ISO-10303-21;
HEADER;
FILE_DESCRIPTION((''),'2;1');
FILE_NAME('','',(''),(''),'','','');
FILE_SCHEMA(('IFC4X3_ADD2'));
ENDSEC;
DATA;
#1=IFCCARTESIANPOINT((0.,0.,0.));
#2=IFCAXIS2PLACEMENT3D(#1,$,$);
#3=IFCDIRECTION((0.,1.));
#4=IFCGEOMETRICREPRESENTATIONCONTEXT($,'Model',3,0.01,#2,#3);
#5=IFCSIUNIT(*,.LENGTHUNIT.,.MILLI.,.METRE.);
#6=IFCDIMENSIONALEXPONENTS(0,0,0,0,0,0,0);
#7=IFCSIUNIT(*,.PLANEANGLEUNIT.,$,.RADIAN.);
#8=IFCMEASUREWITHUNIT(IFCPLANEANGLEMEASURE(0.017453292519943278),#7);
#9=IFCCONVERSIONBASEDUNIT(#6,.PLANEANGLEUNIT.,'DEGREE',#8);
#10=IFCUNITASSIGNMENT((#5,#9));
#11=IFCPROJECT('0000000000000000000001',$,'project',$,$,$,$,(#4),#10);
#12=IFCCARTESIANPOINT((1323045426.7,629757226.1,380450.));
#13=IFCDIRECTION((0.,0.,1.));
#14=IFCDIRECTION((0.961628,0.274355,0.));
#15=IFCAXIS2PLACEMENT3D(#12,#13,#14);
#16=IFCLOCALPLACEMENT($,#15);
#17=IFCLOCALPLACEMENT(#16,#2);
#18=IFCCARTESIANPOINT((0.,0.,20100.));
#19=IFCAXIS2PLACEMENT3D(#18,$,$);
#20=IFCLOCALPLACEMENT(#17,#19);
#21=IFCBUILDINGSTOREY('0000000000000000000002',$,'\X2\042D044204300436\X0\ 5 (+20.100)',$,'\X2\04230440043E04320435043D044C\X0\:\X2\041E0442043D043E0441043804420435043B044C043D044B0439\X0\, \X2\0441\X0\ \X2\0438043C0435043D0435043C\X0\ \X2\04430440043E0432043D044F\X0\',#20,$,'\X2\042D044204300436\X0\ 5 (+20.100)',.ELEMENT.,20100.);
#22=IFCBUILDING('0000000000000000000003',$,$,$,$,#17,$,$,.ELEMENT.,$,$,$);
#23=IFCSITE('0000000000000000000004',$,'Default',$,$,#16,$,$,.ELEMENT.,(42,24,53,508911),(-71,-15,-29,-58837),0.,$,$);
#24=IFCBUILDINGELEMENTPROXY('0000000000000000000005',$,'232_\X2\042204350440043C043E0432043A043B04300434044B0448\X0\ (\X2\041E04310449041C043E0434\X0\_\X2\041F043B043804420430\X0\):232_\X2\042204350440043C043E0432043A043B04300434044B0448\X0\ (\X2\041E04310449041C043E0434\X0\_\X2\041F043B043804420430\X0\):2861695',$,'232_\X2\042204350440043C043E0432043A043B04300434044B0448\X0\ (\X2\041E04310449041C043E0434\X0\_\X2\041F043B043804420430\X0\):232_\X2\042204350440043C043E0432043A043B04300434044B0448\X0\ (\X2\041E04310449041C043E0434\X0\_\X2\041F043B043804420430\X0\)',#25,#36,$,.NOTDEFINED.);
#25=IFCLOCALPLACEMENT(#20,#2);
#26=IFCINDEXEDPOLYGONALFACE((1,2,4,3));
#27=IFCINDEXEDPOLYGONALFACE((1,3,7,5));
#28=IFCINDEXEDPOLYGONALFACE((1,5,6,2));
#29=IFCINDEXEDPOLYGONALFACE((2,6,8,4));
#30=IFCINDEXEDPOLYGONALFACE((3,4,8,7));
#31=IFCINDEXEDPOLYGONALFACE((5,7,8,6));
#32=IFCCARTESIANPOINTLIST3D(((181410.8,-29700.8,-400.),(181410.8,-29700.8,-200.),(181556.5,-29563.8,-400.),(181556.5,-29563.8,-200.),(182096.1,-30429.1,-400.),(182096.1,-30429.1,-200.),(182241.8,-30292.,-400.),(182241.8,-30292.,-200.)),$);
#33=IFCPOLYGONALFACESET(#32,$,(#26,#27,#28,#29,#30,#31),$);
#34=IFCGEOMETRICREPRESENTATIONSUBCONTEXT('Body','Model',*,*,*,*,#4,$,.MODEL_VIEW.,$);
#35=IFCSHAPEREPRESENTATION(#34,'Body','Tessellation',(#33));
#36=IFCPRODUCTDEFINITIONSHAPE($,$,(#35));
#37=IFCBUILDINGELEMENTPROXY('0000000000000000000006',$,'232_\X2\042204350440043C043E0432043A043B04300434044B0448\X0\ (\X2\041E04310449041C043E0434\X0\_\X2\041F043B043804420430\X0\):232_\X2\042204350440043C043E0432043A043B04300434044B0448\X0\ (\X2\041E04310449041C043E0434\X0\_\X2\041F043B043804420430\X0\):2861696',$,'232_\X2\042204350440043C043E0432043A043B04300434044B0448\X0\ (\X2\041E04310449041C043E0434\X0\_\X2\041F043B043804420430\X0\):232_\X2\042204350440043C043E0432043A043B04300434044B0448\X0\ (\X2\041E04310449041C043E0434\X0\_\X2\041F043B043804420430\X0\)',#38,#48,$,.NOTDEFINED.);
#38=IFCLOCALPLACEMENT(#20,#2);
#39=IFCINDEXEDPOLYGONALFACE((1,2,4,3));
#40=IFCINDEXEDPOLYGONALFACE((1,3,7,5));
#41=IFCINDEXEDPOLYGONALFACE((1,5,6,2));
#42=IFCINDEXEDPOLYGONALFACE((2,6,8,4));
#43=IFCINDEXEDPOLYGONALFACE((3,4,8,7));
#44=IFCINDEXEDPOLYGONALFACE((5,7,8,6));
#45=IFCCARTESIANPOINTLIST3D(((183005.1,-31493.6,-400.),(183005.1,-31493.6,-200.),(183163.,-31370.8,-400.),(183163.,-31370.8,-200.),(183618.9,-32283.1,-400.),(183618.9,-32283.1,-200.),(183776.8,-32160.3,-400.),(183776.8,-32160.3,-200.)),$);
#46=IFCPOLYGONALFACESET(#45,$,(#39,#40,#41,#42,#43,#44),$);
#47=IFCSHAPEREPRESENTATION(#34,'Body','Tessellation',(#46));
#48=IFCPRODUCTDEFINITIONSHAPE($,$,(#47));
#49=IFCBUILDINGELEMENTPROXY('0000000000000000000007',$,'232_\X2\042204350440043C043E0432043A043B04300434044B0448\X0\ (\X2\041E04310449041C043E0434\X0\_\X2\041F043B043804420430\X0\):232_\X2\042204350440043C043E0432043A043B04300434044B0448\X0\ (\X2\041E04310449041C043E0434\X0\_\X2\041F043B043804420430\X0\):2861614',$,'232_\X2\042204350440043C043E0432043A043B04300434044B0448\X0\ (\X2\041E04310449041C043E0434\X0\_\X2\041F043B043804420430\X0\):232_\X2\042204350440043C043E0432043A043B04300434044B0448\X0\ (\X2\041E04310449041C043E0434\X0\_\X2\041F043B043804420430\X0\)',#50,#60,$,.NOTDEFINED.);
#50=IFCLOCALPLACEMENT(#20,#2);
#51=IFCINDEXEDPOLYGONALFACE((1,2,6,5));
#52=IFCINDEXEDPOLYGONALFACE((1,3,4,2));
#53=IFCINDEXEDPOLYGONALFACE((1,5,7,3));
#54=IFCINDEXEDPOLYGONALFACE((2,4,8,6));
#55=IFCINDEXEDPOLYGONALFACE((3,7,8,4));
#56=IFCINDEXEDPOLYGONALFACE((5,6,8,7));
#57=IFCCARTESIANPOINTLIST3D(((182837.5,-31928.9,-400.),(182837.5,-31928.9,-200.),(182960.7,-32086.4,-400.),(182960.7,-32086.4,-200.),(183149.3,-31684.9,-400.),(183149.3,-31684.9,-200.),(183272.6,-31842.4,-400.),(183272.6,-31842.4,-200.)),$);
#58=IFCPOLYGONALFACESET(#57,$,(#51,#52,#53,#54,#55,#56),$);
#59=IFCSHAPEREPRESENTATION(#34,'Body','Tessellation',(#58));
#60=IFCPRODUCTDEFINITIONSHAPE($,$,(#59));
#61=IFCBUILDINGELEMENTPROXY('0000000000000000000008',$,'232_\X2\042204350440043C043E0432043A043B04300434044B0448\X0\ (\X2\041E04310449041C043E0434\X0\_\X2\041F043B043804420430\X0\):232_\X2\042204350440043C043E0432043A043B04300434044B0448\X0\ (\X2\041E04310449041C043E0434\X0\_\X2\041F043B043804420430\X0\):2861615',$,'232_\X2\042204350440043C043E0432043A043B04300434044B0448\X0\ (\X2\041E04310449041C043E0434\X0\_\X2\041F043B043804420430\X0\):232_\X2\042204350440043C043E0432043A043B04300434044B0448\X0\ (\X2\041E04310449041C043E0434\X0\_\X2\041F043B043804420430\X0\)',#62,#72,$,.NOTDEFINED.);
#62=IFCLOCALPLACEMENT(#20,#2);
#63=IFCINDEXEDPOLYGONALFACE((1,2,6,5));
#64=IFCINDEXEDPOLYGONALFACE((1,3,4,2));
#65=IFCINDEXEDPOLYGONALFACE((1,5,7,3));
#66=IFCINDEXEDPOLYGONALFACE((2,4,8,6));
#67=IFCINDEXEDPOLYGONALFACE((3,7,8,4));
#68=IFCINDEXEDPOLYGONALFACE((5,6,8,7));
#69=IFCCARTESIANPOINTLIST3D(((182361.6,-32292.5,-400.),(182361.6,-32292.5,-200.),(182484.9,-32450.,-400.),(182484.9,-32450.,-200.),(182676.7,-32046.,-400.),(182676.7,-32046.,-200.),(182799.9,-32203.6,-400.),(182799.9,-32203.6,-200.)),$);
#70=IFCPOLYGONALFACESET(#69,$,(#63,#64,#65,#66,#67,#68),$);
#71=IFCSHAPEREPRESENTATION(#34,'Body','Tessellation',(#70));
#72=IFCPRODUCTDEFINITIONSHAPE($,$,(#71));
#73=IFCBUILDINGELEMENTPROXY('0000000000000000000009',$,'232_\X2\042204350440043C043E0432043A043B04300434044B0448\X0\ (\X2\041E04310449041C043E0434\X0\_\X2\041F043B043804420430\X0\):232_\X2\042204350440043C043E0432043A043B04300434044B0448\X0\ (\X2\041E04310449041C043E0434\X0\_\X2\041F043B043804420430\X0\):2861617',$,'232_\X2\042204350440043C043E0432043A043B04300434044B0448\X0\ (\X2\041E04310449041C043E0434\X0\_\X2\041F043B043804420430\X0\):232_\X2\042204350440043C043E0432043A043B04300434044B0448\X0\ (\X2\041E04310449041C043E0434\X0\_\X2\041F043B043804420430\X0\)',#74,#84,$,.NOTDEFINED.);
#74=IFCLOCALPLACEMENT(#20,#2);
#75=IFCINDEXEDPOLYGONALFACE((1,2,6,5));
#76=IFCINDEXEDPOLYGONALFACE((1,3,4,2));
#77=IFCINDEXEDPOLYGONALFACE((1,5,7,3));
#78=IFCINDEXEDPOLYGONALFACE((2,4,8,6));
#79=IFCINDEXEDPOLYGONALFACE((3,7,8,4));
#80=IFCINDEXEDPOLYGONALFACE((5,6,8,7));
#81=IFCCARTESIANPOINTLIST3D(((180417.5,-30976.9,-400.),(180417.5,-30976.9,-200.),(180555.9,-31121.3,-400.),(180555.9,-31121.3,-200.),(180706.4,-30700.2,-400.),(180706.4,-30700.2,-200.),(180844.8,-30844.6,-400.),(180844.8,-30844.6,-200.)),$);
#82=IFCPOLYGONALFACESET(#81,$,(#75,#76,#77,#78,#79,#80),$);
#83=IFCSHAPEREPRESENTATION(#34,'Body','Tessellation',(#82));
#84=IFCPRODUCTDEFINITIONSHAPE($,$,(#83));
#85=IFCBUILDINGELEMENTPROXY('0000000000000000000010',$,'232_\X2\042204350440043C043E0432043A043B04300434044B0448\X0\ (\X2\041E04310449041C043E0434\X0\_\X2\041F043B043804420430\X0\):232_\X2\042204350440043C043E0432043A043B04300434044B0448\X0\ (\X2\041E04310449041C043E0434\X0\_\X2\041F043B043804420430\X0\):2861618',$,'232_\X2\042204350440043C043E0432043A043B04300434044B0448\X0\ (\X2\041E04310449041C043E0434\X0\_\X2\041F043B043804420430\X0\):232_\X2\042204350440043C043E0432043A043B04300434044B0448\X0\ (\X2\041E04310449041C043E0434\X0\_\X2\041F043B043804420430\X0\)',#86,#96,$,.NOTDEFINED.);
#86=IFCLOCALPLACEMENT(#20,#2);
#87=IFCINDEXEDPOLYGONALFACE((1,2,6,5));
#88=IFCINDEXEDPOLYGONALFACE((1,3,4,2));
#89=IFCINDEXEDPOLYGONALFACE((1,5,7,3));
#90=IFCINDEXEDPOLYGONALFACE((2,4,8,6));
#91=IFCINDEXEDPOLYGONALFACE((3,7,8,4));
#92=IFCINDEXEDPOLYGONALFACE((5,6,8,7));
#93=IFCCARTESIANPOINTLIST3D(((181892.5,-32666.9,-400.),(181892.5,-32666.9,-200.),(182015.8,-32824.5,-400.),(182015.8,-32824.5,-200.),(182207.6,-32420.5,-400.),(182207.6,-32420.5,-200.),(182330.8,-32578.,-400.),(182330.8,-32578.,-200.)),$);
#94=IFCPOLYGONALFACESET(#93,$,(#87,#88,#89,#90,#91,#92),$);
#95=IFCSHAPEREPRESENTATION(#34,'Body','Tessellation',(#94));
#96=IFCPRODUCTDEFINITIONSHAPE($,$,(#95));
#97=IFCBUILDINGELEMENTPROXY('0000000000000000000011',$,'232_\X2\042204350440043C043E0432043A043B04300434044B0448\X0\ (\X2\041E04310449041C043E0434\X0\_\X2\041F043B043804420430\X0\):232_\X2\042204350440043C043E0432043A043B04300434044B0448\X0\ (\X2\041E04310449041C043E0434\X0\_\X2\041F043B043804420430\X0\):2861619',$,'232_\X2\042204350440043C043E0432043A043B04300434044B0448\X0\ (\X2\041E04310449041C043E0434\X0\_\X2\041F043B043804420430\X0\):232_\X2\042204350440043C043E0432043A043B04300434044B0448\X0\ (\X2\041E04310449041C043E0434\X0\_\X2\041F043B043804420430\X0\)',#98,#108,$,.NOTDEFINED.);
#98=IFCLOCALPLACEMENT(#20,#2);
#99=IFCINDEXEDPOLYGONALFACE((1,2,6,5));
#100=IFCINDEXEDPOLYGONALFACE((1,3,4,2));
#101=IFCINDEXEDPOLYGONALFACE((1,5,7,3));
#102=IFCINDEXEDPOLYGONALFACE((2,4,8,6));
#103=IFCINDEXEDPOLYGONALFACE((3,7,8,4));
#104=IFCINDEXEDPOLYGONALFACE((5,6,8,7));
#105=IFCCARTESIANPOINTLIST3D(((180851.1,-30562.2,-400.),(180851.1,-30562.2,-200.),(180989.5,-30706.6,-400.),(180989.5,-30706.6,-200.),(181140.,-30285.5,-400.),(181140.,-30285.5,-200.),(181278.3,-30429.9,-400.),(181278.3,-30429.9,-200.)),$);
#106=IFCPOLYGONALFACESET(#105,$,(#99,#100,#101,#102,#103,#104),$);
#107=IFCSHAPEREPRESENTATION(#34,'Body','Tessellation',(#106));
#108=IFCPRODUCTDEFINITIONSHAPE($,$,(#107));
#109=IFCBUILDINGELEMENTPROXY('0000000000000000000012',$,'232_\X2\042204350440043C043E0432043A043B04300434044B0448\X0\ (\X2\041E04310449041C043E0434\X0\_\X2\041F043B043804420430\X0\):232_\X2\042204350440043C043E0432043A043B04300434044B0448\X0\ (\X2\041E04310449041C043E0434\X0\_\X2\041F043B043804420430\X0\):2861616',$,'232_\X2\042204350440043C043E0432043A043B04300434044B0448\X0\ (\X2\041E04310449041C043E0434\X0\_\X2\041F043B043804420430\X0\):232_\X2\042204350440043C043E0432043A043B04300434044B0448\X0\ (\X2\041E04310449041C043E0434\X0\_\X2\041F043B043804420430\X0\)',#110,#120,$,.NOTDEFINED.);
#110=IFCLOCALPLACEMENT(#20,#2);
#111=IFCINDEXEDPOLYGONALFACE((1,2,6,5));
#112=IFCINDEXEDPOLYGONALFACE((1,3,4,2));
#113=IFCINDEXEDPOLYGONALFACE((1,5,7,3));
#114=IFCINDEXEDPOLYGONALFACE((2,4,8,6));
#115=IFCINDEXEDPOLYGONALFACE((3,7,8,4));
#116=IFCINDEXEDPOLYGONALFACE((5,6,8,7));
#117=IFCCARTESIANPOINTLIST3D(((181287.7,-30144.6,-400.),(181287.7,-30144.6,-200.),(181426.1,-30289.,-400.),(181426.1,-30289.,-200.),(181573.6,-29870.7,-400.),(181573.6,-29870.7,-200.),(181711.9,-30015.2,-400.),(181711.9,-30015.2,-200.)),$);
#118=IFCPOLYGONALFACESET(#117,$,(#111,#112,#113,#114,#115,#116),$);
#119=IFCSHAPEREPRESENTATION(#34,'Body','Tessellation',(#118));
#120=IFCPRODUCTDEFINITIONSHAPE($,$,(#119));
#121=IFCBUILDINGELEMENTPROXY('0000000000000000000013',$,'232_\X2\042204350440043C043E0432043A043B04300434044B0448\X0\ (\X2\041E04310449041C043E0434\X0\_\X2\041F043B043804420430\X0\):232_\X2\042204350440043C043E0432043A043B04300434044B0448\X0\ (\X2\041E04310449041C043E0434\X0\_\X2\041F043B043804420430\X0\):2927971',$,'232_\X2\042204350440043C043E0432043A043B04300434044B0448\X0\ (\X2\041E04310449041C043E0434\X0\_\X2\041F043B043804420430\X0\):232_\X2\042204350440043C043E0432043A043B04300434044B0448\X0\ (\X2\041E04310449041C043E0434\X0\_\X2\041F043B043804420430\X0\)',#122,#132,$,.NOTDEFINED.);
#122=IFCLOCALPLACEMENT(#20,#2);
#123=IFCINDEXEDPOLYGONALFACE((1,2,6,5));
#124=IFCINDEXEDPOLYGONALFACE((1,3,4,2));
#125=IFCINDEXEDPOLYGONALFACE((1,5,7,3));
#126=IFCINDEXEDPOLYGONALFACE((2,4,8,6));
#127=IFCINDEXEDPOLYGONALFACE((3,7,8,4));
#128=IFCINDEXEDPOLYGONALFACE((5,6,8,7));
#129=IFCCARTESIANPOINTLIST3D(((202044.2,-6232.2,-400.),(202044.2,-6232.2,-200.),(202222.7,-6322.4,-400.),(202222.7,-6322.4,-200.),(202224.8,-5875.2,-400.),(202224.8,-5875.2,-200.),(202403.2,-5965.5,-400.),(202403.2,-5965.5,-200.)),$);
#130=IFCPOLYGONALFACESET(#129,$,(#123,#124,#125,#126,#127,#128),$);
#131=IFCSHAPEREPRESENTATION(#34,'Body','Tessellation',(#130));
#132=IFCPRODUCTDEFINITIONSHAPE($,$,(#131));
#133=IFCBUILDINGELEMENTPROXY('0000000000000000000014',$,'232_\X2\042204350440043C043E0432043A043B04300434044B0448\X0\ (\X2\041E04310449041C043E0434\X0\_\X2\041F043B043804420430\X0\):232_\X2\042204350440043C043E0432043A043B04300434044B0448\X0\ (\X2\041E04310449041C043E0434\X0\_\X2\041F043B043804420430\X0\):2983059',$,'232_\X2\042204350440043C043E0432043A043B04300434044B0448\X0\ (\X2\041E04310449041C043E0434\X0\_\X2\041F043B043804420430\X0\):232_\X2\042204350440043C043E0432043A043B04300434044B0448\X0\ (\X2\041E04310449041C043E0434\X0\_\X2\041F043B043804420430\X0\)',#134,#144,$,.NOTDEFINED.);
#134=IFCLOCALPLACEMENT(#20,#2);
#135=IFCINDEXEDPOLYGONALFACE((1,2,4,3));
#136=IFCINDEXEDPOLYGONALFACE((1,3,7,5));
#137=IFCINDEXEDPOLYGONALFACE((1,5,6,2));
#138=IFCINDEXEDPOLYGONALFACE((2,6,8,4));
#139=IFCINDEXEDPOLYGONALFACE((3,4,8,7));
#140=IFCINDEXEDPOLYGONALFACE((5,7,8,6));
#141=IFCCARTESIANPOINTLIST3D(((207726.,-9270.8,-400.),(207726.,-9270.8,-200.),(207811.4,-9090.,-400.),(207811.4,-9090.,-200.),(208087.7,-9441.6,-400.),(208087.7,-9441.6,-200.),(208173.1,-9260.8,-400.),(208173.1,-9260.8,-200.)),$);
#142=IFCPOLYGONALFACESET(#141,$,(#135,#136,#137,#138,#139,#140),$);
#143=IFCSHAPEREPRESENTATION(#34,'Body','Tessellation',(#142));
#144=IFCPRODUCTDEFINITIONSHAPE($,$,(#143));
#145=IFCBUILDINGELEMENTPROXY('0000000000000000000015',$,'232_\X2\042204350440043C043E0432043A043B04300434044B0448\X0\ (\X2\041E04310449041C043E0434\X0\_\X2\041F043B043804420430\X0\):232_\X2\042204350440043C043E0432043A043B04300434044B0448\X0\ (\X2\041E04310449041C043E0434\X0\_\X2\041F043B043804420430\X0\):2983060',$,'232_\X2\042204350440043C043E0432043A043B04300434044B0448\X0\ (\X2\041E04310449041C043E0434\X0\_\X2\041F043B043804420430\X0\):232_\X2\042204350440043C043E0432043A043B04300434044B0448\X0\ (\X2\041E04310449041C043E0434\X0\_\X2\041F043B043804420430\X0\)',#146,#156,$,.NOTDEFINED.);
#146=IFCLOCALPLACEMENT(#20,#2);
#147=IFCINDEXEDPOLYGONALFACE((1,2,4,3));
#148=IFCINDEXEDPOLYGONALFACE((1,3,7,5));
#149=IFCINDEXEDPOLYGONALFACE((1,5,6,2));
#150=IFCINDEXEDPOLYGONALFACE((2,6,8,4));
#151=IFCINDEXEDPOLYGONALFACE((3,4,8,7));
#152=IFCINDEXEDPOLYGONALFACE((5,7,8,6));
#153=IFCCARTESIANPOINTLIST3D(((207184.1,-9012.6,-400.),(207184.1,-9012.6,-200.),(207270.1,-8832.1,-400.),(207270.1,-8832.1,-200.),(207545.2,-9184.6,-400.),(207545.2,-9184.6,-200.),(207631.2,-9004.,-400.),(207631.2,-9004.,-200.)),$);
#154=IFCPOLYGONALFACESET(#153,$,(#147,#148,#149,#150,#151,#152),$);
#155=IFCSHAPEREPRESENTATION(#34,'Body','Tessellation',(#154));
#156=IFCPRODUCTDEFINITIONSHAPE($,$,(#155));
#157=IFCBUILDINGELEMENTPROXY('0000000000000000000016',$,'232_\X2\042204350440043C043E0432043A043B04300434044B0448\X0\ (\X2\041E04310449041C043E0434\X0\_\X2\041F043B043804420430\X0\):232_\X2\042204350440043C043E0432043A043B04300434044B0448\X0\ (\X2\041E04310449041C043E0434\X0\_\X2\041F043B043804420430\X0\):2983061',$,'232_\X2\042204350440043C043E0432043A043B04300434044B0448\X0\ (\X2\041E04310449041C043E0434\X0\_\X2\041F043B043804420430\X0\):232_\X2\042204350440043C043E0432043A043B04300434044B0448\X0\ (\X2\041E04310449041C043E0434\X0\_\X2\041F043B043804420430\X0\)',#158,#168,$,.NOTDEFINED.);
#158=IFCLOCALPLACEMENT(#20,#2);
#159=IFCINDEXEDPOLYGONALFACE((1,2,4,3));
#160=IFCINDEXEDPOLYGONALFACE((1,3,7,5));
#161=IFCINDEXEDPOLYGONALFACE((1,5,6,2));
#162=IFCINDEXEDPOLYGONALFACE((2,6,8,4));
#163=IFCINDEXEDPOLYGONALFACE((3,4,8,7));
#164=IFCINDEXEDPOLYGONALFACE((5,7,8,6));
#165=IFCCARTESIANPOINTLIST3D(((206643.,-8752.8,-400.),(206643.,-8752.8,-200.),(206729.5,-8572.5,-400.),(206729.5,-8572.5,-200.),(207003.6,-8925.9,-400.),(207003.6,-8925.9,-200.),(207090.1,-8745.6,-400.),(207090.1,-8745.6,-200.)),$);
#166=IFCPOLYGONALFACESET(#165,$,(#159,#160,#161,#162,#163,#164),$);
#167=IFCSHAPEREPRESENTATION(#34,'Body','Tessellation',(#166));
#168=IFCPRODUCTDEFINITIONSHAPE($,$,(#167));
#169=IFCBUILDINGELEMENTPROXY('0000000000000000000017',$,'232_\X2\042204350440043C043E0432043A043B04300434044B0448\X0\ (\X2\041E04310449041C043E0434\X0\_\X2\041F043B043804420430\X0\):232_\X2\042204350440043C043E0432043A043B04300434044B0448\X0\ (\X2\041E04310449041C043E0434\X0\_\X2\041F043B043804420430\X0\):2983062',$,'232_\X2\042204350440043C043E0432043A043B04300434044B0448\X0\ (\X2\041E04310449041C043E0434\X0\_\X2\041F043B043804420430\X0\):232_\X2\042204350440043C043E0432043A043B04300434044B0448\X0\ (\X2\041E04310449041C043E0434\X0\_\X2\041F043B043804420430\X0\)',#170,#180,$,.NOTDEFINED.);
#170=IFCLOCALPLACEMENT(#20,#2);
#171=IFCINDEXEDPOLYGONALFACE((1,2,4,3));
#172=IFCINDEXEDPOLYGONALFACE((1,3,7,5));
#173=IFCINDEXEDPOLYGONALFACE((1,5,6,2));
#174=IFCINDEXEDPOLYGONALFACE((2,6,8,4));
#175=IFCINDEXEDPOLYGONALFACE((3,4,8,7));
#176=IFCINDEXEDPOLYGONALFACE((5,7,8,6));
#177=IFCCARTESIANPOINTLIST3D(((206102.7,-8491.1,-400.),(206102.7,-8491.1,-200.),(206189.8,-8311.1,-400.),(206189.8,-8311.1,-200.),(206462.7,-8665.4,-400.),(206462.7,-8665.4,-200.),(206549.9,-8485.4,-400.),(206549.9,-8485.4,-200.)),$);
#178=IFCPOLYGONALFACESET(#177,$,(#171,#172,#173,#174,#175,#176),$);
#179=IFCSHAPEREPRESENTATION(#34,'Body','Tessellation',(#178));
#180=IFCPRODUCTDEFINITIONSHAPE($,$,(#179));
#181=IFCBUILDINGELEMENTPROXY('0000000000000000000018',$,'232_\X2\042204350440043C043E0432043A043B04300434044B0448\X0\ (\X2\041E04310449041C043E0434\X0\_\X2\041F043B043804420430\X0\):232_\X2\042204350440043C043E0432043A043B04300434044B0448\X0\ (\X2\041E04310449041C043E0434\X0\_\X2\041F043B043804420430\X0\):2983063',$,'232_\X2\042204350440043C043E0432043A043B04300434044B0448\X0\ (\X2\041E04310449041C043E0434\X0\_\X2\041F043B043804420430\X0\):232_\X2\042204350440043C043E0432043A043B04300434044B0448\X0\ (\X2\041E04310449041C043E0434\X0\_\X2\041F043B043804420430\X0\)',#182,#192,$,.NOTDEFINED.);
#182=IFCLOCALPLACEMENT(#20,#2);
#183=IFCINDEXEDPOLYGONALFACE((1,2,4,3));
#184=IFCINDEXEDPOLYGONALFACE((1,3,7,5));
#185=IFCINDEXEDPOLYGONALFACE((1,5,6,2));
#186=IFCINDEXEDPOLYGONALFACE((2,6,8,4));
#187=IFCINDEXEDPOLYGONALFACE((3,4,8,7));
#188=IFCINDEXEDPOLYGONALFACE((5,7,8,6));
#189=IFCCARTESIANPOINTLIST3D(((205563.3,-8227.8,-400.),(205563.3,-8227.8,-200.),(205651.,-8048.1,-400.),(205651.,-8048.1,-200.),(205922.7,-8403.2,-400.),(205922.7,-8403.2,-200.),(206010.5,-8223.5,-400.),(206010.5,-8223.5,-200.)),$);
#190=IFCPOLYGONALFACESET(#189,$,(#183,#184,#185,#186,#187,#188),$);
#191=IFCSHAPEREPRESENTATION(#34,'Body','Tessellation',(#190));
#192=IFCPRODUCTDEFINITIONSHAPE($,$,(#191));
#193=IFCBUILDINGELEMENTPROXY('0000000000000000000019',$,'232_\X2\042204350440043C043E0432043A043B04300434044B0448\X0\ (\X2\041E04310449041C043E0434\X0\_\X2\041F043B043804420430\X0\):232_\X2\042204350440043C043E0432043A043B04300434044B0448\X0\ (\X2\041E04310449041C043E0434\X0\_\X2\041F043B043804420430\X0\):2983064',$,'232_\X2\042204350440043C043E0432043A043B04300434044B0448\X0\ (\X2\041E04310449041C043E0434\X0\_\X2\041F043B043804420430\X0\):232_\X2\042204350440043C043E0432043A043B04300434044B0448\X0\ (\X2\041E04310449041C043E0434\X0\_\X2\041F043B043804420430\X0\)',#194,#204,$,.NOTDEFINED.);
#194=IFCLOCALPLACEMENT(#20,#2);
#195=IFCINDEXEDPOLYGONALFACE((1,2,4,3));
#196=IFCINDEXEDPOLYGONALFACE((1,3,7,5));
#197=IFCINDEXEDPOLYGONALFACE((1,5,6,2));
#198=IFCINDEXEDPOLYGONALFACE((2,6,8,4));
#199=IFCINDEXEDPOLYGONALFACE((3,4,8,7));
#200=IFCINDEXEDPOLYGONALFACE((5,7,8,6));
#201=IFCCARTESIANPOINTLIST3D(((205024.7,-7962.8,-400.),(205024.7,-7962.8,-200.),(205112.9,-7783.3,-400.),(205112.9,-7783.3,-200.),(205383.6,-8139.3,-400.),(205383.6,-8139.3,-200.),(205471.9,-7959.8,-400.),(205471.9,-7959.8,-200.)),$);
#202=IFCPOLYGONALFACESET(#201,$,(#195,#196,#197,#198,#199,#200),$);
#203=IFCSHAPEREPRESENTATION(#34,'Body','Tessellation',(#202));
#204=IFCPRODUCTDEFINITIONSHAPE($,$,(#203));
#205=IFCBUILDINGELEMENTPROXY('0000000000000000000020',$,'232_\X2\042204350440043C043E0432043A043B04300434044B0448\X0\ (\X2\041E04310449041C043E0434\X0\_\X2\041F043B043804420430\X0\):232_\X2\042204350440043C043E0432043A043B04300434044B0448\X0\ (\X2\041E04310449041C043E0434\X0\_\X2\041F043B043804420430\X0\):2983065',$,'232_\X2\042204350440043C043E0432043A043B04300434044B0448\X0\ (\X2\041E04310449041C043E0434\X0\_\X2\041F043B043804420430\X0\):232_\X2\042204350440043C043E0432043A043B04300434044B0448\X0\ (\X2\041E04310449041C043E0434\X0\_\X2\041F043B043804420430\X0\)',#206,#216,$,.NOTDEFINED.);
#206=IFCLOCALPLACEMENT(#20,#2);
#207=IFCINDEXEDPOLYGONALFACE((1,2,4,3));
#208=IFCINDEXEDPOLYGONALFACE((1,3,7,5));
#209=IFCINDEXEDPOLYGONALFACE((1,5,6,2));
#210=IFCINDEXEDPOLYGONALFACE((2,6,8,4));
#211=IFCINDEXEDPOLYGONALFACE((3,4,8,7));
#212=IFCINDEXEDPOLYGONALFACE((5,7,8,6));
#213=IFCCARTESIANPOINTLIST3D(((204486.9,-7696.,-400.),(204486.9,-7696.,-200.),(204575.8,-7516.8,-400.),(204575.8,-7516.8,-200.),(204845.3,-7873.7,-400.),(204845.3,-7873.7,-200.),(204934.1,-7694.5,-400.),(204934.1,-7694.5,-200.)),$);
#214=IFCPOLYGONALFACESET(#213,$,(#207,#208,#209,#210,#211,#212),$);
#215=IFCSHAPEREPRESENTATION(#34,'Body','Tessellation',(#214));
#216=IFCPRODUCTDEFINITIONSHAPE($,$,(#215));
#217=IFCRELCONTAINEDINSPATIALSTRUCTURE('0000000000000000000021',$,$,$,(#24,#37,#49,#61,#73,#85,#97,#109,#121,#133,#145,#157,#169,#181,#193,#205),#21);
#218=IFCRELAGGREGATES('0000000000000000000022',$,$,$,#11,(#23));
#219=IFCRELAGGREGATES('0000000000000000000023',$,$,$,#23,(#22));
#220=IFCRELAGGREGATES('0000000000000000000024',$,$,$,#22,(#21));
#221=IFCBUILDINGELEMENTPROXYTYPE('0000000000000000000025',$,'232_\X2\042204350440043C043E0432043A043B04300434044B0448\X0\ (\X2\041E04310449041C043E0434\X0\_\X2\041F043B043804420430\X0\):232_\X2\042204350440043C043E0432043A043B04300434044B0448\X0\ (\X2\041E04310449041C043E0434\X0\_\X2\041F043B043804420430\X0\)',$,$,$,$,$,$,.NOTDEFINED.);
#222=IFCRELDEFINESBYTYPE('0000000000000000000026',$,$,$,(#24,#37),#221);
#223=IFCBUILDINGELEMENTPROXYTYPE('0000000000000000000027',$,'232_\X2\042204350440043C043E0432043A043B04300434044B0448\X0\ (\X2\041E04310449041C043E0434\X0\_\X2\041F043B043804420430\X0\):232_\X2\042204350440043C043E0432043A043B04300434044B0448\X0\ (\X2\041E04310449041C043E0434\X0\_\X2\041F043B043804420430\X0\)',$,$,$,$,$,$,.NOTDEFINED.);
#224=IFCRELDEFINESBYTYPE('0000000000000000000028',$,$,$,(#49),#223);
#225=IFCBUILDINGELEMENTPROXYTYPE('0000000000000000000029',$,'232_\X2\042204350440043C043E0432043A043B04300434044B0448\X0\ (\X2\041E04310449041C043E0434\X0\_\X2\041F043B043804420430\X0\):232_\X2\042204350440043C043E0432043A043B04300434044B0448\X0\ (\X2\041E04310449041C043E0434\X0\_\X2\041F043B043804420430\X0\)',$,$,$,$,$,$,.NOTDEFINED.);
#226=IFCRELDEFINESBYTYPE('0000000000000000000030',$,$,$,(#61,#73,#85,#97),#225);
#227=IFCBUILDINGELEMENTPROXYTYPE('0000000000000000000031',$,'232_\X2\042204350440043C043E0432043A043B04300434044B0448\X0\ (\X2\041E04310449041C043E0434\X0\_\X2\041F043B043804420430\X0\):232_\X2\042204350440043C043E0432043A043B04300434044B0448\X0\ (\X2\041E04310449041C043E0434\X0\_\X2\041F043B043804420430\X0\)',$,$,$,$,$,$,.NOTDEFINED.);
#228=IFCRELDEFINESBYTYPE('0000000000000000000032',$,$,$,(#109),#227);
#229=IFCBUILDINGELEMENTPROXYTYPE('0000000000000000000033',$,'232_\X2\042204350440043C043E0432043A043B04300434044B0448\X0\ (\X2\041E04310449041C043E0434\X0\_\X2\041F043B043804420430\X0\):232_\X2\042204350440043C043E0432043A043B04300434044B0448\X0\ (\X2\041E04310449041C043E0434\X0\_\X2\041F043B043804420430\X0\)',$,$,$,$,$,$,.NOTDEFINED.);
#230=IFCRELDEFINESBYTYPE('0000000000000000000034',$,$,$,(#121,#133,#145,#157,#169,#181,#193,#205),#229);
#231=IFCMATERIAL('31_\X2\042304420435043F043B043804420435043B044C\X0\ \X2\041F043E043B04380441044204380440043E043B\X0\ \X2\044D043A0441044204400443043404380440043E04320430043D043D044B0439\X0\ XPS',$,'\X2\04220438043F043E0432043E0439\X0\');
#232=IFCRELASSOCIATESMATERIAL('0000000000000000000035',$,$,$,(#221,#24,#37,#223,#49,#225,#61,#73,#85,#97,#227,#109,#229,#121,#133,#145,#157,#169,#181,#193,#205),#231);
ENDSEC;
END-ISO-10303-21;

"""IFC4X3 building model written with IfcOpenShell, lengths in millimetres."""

from ifc_helpers import new_model, entity, si_unit, converted_unit, direction, frame, origin, origin_2d_with_axis, place, context, subcontext, project, spatial, rectangle, extrude, source, transform, mapped, material, type_object, type_shapes, element, save


model = new_model("IFC4X3")

# Units and contexts
model_context = context("Model", 3, precision=0.01, world=origin(), true_north=direction((0.0, 1.0)))
body_context = subcontext(model_context, "Body", "Model", "MODEL_VIEW")
ifc_project = project(units=[si_unit("LENGTHUNIT", "METRE", prefix="MILLI"), converted_unit("PLANEANGLEUNIT", "DEGREE", entity("IfcPlaneAngleMeasure", 0.017453292519943278), si_unit("PLANEANGLEUNIT", "RADIAN"), dimensions=[0, 0, 0, 0, 0, 0, 0])], contexts=[model_context])

# Site, building, storey
site_placement = place(None, frame((1323045426.7, 629757226.1, 380450.0), z_axis=(0.0, 0.0, 1.0), x_axis=(0.961628, 0.274355, 0.0)))
site = spatial("IfcSite", under=ifc_project, at=site_placement, Name="Default", CompositionType="ELEMENT", RefLatitude=(42, 24, 53, 508911), RefLongitude=(-71, -15, -29, -58837), RefElevation=0.0)
building_placement = place(site_placement, origin())
building = spatial("IfcBuilding", under=site, at=building_placement, CompositionType="ELEMENT")
storey_placement = place(building_placement, frame((0.0, 0.0, 20100.0)))
storey = spatial("IfcBuildingStorey", under=building, at=storey_placement, Name="Этаж 5 (+20.100)", ObjectType="Уровень:Относительный, с именем уровня", LongName="Этаж 5 (+20.100)", CompositionType="ELEMENT", Elevation=20100.0)

# Building element proxies
ifc_material = material(Name="31_Утеплитель Полистирол экструдированный XPS", Category="Типовой")
building_element_proxy_type_1 = type_object("IfcBuildingElementProxyType", Name="232_Термовкладыш (ОбщМод_Плита):232_Термовкладыш (ОбщМод_Плита)", PredefinedType="NOTDEFINED", material=ifc_material)
shared_shape_1 = source(origin(), body_context, "Body", "SweptSolid", [
    extrude(rectangle(XDim=1000.0, YDim=200.0, at=origin_2d_with_axis()), frame((500.0, 0.0, -200.0), z_axis=(0.0, 0.0, 1.0), x_axis=(-1.0, 0.0, 0.0)), (0.0, 0.0, 1.0), 200.0),
])
type_shapes(building_element_proxy_type_1, [shared_shape_1])
for number, where, z_axis, x_axis, name in (
    (1, (181483.6, -29632.3, -200.0), (0.0, 0.0, 1.0), (0.685295, -0.728265, 0.0), "232_Термовкладыш (ОбщМод_Плита):232_Термовкладыш (ОбщМод_Плита):2861695"),
    (2, (183084.1, -31432.2, -200.0), (0.0, 0.0, 1.0), (0.613807, -0.789456, 0.0), "232_Термовкладыш (ОбщМод_Плита):232_Термовкладыш (ОбщМод_Плита):2861696"),
):
    element("IfcBuildingElementProxy", number, at=place(storey_placement, frame(where, z_axis=z_axis, x_axis=x_axis)), inside=storey, type_object=building_element_proxy_type_1, material=ifc_material, Name=name, ObjectType="232_Термовкладыш (ОбщМод_Плита):232_Термовкладыш (ОбщМод_Плита)", PredefinedType="NOTDEFINED", context=body_context, shape_type="MappedRepresentation", body=[
        mapped(shared_shape_1, transform((0.0, 0.0, 0.0), scale=1.0)),
    ])
building_element_proxy_type_2 = type_object("IfcBuildingElementProxyType", Name="232_Термовкладыш (ОбщМод_Плита):232_Термовкладыш (ОбщМод_Плита)", PredefinedType="NOTDEFINED", material=ifc_material)
shared_shape_2 = source(origin(), body_context, "Body", "SweptSolid", [
    extrude(rectangle(XDim=200.0, YDim=395.9, at=origin_2d_with_axis()), frame((100.0, 0.0, -200.0), z_axis=(0.0, 0.0, 1.0), x_axis=(-1.0, 0.0, 0.0)), (0.0, 0.0, 1.0), 200.0),
])
type_shapes(building_element_proxy_type_2, [shared_shape_2])
proxy_1_placement = place(storey_placement, frame((182993.4, -31806.9, -200.0), z_axis=(0.0, 0.0, 1.0), x_axis=(0.616214, -0.787579, 0.0)))
element("IfcBuildingElementProxy", 3, at=proxy_1_placement, inside=storey, type_object=building_element_proxy_type_2, material=ifc_material, Name="232_Термовкладыш (ОбщМод_Плита):232_Термовкладыш (ОбщМод_Плита):2861614", ObjectType="232_Термовкладыш (ОбщМод_Плита):232_Термовкладыш (ОбщМод_Плита)", PredefinedType="NOTDEFINED", context=body_context, shape_type="MappedRepresentation", body=[
    mapped(shared_shape_2, transform((0.0, 0.0, 0.0), scale=1.0)),
])
building_element_proxy_type_3 = type_object("IfcBuildingElementProxyType", Name="232_Термовкладыш (ОбщМод_Плита):232_Термовкладыш (ОбщМод_Плита)", PredefinedType="NOTDEFINED", material=ifc_material)
shared_shape_3 = source(origin(), body_context, "Body", "SweptSolid", [
    extrude(rectangle(XDim=200.0, YDim=400.0, at=origin_2d_with_axis()), frame((100.0, 0.0, -200.0), z_axis=(0.0, 0.0, 1.0), x_axis=(-1.0, 0.0, 0.0)), (0.0, 0.0, 1.0), 200.0),
])
type_shapes(building_element_proxy_type_3, [shared_shape_3])
for number, where, z_axis, x_axis, name in (
    (4, (182519.1, -32169.3, -200.0), (0.0, 0.0, 1.0), (0.616214, -0.787579, 0.0), "232_Термовкладыш (ОбщМод_Плита):232_Термовкладыш (ОбщМод_Плита):2861615"),
    (5, (180562.0, -30838.6, -200.0), (0.0, 0.0, 1.0), (0.691767, -0.722121, 0.0), "232_Термовкладыш (ОбщМод_Плита):232_Термовкладыш (ОбщМод_Плита):2861617"),
    (6, (182050.1, -32543.7, -200.0), (0.0, 0.0, 1.0), (0.616214, -0.787579, 0.0), "232_Термовкладыш (ОбщМод_Плита):232_Термовкладыш (ОбщМод_Плита):2861618"),
    (7, (180995.6, -30423.8, -200.0), (0.0, 0.0, 1.0), (0.691767, -0.722121, 0.0), "232_Термовкладыш (ОбщМод_Плита):232_Термовкладыш (ОбщМод_Плита):2861619"),
):
    element("IfcBuildingElementProxy", number, at=place(storey_placement, frame(where, z_axis=z_axis, x_axis=x_axis)), inside=storey, type_object=building_element_proxy_type_3, material=ifc_material, Name=name, ObjectType="232_Термовкладыш (ОбщМод_Плита):232_Термовкладыш (ОбщМод_Плита)", PredefinedType="NOTDEFINED", context=body_context, shape_type="MappedRepresentation", body=[
        mapped(shared_shape_3, transform((0.0, 0.0, 0.0), scale=1.0)),
    ])
building_element_proxy_type_4 = type_object("IfcBuildingElementProxyType", Name="232_Термовкладыш (ОбщМод_Плита):232_Термовкладыш (ОбщМод_Плита)", PredefinedType="NOTDEFINED", material=ifc_material)
shared_shape_4 = source(origin(), body_context, "Body", "SweptSolid", [
    extrude(rectangle(XDim=200.0, YDim=395.9, at=origin_2d_with_axis()), frame((100.0, 0.0, -200.0), z_axis=(0.0, 0.0, 1.0), x_axis=(-1.0, 0.0, 0.0)), (0.0, 0.0, 1.0), 200.0),
])
type_shapes(building_element_proxy_type_4, [shared_shape_4])
proxy_2_placement = place(storey_placement, frame((181430.6, -30007.7, -200.0), z_axis=(0.0, 0.0, 1.0), x_axis=(0.691767, -0.722121, 0.0)))
element("IfcBuildingElementProxy", 8, at=proxy_2_placement, inside=storey, type_object=building_element_proxy_type_4, material=ifc_material, Name="232_Термовкладыш (ОбщМод_Плита):232_Термовкладыш (ОбщМод_Плита):2861616", ObjectType="232_Термовкладыш (ОбщМод_Плита):232_Термовкладыш (ОбщМод_Плита)", PredefinedType="NOTDEFINED", context=body_context, shape_type="MappedRepresentation", body=[
    mapped(shared_shape_4, transform((0.0, 0.0, 0.0), scale=1.0)),
])
building_element_proxy_type_5 = type_object("IfcBuildingElementProxyType", Name="232_Термовкладыш (ОбщМод_Плита):232_Термовкладыш (ОбщМод_Плита)", PredefinedType="NOTDEFINED", material=ifc_material)
shared_shape_5 = source(origin(), body_context, "Body", "SweptSolid", [
    extrude(rectangle(XDim=400.0, YDim=200.0, at=origin_2d_with_axis()), frame((200.0, 0.0, -200.0), z_axis=(0.0, 0.0, 1.0), x_axis=(-1.0, 0.0, 0.0)), (0.0, 0.0, 1.0), 200.0),
])
type_shapes(building_element_proxy_type_5, [shared_shape_5])
for number, where, z_axis, x_axis, name in (
    (9, (202133.5, -6277.3, -200.0), (0.0, 0.0, 1.0), (0.451327, 0.892359, 0.0), "232_Термовкладыш (ОбщМод_Плита):232_Термовкладыш (ОбщМод_Плита):2927971"),
    (10, (208130.4, -9351.2, -200.0), (0.0, 0.0, 1.0), (-0.904237, 0.42703, 0.0), "232_Термовкладыш (ОбщМод_Плита):232_Термовкладыш (ОбщМод_Плита):2983059"),
    (11, (207588.2, -9094.3, -200.0), (0.0, 0.0, 1.0), (-0.902872, 0.42991, 0.0), "232_Термовкладыш (ОбщМод_Плита):232_Термовкладыш (ОбщМод_Плита):2983060"),
    (12, (207046.8, -8835.7, -200.0), (0.0, 0.0, 1.0), (-0.901497, 0.432786, 0.0), "232_Термовкладыш (ОбщМод_Плита):232_Термовкладыш (ОбщМод_Плита):2983061"),
    (13, (206506.3, -8575.4, -200.0), (0.0, 0.0, 1.0), (-0.900113, 0.435657, 0.0), "232_Термовкладыш (ОбщМод_Плита):232_Термовкладыш (ОбщМод_Плита):2983062"),
    (14, (205966.6, -8313.3, -200.0), (0.0, 0.0, 1.0), (-0.89872, 0.438523, 0.0), "232_Термовкладыш (ОбщМод_Плита):232_Термовкладыш (ОбщМод_Плита):2983063"),
    (15, (205427.7, -8049.6, -200.0), (0.0, 0.0, 1.0), (-0.897318, 0.441385, 0.0), "232_Термовкладыш (ОбщМод_Плита):232_Термовкладыш (ОбщМод_Плита):2983064"),
    (16, (204889.7, -7784.1, -200.0), (0.0, 0.0, 1.0), (-0.895906, 0.444243, 0.0), "232_Термовкладыш (ОбщМод_Плита):232_Термовкладыш (ОбщМод_Плита):2983065"),
):
    element("IfcBuildingElementProxy", number, at=place(storey_placement, frame(where, z_axis=z_axis, x_axis=x_axis)), inside=storey, type_object=building_element_proxy_type_5, material=ifc_material, Name=name, ObjectType="232_Термовкладыш (ОбщМод_Плита):232_Термовкладыш (ОбщМод_Плита)", PredefinedType="NOTDEFINED", context=body_context, shape_type="MappedRepresentation", body=[
        mapped(shared_shape_5, transform((0.0, 0.0, 0.0), scale=1.0)),
    ])

save(model, "model.ifc")
